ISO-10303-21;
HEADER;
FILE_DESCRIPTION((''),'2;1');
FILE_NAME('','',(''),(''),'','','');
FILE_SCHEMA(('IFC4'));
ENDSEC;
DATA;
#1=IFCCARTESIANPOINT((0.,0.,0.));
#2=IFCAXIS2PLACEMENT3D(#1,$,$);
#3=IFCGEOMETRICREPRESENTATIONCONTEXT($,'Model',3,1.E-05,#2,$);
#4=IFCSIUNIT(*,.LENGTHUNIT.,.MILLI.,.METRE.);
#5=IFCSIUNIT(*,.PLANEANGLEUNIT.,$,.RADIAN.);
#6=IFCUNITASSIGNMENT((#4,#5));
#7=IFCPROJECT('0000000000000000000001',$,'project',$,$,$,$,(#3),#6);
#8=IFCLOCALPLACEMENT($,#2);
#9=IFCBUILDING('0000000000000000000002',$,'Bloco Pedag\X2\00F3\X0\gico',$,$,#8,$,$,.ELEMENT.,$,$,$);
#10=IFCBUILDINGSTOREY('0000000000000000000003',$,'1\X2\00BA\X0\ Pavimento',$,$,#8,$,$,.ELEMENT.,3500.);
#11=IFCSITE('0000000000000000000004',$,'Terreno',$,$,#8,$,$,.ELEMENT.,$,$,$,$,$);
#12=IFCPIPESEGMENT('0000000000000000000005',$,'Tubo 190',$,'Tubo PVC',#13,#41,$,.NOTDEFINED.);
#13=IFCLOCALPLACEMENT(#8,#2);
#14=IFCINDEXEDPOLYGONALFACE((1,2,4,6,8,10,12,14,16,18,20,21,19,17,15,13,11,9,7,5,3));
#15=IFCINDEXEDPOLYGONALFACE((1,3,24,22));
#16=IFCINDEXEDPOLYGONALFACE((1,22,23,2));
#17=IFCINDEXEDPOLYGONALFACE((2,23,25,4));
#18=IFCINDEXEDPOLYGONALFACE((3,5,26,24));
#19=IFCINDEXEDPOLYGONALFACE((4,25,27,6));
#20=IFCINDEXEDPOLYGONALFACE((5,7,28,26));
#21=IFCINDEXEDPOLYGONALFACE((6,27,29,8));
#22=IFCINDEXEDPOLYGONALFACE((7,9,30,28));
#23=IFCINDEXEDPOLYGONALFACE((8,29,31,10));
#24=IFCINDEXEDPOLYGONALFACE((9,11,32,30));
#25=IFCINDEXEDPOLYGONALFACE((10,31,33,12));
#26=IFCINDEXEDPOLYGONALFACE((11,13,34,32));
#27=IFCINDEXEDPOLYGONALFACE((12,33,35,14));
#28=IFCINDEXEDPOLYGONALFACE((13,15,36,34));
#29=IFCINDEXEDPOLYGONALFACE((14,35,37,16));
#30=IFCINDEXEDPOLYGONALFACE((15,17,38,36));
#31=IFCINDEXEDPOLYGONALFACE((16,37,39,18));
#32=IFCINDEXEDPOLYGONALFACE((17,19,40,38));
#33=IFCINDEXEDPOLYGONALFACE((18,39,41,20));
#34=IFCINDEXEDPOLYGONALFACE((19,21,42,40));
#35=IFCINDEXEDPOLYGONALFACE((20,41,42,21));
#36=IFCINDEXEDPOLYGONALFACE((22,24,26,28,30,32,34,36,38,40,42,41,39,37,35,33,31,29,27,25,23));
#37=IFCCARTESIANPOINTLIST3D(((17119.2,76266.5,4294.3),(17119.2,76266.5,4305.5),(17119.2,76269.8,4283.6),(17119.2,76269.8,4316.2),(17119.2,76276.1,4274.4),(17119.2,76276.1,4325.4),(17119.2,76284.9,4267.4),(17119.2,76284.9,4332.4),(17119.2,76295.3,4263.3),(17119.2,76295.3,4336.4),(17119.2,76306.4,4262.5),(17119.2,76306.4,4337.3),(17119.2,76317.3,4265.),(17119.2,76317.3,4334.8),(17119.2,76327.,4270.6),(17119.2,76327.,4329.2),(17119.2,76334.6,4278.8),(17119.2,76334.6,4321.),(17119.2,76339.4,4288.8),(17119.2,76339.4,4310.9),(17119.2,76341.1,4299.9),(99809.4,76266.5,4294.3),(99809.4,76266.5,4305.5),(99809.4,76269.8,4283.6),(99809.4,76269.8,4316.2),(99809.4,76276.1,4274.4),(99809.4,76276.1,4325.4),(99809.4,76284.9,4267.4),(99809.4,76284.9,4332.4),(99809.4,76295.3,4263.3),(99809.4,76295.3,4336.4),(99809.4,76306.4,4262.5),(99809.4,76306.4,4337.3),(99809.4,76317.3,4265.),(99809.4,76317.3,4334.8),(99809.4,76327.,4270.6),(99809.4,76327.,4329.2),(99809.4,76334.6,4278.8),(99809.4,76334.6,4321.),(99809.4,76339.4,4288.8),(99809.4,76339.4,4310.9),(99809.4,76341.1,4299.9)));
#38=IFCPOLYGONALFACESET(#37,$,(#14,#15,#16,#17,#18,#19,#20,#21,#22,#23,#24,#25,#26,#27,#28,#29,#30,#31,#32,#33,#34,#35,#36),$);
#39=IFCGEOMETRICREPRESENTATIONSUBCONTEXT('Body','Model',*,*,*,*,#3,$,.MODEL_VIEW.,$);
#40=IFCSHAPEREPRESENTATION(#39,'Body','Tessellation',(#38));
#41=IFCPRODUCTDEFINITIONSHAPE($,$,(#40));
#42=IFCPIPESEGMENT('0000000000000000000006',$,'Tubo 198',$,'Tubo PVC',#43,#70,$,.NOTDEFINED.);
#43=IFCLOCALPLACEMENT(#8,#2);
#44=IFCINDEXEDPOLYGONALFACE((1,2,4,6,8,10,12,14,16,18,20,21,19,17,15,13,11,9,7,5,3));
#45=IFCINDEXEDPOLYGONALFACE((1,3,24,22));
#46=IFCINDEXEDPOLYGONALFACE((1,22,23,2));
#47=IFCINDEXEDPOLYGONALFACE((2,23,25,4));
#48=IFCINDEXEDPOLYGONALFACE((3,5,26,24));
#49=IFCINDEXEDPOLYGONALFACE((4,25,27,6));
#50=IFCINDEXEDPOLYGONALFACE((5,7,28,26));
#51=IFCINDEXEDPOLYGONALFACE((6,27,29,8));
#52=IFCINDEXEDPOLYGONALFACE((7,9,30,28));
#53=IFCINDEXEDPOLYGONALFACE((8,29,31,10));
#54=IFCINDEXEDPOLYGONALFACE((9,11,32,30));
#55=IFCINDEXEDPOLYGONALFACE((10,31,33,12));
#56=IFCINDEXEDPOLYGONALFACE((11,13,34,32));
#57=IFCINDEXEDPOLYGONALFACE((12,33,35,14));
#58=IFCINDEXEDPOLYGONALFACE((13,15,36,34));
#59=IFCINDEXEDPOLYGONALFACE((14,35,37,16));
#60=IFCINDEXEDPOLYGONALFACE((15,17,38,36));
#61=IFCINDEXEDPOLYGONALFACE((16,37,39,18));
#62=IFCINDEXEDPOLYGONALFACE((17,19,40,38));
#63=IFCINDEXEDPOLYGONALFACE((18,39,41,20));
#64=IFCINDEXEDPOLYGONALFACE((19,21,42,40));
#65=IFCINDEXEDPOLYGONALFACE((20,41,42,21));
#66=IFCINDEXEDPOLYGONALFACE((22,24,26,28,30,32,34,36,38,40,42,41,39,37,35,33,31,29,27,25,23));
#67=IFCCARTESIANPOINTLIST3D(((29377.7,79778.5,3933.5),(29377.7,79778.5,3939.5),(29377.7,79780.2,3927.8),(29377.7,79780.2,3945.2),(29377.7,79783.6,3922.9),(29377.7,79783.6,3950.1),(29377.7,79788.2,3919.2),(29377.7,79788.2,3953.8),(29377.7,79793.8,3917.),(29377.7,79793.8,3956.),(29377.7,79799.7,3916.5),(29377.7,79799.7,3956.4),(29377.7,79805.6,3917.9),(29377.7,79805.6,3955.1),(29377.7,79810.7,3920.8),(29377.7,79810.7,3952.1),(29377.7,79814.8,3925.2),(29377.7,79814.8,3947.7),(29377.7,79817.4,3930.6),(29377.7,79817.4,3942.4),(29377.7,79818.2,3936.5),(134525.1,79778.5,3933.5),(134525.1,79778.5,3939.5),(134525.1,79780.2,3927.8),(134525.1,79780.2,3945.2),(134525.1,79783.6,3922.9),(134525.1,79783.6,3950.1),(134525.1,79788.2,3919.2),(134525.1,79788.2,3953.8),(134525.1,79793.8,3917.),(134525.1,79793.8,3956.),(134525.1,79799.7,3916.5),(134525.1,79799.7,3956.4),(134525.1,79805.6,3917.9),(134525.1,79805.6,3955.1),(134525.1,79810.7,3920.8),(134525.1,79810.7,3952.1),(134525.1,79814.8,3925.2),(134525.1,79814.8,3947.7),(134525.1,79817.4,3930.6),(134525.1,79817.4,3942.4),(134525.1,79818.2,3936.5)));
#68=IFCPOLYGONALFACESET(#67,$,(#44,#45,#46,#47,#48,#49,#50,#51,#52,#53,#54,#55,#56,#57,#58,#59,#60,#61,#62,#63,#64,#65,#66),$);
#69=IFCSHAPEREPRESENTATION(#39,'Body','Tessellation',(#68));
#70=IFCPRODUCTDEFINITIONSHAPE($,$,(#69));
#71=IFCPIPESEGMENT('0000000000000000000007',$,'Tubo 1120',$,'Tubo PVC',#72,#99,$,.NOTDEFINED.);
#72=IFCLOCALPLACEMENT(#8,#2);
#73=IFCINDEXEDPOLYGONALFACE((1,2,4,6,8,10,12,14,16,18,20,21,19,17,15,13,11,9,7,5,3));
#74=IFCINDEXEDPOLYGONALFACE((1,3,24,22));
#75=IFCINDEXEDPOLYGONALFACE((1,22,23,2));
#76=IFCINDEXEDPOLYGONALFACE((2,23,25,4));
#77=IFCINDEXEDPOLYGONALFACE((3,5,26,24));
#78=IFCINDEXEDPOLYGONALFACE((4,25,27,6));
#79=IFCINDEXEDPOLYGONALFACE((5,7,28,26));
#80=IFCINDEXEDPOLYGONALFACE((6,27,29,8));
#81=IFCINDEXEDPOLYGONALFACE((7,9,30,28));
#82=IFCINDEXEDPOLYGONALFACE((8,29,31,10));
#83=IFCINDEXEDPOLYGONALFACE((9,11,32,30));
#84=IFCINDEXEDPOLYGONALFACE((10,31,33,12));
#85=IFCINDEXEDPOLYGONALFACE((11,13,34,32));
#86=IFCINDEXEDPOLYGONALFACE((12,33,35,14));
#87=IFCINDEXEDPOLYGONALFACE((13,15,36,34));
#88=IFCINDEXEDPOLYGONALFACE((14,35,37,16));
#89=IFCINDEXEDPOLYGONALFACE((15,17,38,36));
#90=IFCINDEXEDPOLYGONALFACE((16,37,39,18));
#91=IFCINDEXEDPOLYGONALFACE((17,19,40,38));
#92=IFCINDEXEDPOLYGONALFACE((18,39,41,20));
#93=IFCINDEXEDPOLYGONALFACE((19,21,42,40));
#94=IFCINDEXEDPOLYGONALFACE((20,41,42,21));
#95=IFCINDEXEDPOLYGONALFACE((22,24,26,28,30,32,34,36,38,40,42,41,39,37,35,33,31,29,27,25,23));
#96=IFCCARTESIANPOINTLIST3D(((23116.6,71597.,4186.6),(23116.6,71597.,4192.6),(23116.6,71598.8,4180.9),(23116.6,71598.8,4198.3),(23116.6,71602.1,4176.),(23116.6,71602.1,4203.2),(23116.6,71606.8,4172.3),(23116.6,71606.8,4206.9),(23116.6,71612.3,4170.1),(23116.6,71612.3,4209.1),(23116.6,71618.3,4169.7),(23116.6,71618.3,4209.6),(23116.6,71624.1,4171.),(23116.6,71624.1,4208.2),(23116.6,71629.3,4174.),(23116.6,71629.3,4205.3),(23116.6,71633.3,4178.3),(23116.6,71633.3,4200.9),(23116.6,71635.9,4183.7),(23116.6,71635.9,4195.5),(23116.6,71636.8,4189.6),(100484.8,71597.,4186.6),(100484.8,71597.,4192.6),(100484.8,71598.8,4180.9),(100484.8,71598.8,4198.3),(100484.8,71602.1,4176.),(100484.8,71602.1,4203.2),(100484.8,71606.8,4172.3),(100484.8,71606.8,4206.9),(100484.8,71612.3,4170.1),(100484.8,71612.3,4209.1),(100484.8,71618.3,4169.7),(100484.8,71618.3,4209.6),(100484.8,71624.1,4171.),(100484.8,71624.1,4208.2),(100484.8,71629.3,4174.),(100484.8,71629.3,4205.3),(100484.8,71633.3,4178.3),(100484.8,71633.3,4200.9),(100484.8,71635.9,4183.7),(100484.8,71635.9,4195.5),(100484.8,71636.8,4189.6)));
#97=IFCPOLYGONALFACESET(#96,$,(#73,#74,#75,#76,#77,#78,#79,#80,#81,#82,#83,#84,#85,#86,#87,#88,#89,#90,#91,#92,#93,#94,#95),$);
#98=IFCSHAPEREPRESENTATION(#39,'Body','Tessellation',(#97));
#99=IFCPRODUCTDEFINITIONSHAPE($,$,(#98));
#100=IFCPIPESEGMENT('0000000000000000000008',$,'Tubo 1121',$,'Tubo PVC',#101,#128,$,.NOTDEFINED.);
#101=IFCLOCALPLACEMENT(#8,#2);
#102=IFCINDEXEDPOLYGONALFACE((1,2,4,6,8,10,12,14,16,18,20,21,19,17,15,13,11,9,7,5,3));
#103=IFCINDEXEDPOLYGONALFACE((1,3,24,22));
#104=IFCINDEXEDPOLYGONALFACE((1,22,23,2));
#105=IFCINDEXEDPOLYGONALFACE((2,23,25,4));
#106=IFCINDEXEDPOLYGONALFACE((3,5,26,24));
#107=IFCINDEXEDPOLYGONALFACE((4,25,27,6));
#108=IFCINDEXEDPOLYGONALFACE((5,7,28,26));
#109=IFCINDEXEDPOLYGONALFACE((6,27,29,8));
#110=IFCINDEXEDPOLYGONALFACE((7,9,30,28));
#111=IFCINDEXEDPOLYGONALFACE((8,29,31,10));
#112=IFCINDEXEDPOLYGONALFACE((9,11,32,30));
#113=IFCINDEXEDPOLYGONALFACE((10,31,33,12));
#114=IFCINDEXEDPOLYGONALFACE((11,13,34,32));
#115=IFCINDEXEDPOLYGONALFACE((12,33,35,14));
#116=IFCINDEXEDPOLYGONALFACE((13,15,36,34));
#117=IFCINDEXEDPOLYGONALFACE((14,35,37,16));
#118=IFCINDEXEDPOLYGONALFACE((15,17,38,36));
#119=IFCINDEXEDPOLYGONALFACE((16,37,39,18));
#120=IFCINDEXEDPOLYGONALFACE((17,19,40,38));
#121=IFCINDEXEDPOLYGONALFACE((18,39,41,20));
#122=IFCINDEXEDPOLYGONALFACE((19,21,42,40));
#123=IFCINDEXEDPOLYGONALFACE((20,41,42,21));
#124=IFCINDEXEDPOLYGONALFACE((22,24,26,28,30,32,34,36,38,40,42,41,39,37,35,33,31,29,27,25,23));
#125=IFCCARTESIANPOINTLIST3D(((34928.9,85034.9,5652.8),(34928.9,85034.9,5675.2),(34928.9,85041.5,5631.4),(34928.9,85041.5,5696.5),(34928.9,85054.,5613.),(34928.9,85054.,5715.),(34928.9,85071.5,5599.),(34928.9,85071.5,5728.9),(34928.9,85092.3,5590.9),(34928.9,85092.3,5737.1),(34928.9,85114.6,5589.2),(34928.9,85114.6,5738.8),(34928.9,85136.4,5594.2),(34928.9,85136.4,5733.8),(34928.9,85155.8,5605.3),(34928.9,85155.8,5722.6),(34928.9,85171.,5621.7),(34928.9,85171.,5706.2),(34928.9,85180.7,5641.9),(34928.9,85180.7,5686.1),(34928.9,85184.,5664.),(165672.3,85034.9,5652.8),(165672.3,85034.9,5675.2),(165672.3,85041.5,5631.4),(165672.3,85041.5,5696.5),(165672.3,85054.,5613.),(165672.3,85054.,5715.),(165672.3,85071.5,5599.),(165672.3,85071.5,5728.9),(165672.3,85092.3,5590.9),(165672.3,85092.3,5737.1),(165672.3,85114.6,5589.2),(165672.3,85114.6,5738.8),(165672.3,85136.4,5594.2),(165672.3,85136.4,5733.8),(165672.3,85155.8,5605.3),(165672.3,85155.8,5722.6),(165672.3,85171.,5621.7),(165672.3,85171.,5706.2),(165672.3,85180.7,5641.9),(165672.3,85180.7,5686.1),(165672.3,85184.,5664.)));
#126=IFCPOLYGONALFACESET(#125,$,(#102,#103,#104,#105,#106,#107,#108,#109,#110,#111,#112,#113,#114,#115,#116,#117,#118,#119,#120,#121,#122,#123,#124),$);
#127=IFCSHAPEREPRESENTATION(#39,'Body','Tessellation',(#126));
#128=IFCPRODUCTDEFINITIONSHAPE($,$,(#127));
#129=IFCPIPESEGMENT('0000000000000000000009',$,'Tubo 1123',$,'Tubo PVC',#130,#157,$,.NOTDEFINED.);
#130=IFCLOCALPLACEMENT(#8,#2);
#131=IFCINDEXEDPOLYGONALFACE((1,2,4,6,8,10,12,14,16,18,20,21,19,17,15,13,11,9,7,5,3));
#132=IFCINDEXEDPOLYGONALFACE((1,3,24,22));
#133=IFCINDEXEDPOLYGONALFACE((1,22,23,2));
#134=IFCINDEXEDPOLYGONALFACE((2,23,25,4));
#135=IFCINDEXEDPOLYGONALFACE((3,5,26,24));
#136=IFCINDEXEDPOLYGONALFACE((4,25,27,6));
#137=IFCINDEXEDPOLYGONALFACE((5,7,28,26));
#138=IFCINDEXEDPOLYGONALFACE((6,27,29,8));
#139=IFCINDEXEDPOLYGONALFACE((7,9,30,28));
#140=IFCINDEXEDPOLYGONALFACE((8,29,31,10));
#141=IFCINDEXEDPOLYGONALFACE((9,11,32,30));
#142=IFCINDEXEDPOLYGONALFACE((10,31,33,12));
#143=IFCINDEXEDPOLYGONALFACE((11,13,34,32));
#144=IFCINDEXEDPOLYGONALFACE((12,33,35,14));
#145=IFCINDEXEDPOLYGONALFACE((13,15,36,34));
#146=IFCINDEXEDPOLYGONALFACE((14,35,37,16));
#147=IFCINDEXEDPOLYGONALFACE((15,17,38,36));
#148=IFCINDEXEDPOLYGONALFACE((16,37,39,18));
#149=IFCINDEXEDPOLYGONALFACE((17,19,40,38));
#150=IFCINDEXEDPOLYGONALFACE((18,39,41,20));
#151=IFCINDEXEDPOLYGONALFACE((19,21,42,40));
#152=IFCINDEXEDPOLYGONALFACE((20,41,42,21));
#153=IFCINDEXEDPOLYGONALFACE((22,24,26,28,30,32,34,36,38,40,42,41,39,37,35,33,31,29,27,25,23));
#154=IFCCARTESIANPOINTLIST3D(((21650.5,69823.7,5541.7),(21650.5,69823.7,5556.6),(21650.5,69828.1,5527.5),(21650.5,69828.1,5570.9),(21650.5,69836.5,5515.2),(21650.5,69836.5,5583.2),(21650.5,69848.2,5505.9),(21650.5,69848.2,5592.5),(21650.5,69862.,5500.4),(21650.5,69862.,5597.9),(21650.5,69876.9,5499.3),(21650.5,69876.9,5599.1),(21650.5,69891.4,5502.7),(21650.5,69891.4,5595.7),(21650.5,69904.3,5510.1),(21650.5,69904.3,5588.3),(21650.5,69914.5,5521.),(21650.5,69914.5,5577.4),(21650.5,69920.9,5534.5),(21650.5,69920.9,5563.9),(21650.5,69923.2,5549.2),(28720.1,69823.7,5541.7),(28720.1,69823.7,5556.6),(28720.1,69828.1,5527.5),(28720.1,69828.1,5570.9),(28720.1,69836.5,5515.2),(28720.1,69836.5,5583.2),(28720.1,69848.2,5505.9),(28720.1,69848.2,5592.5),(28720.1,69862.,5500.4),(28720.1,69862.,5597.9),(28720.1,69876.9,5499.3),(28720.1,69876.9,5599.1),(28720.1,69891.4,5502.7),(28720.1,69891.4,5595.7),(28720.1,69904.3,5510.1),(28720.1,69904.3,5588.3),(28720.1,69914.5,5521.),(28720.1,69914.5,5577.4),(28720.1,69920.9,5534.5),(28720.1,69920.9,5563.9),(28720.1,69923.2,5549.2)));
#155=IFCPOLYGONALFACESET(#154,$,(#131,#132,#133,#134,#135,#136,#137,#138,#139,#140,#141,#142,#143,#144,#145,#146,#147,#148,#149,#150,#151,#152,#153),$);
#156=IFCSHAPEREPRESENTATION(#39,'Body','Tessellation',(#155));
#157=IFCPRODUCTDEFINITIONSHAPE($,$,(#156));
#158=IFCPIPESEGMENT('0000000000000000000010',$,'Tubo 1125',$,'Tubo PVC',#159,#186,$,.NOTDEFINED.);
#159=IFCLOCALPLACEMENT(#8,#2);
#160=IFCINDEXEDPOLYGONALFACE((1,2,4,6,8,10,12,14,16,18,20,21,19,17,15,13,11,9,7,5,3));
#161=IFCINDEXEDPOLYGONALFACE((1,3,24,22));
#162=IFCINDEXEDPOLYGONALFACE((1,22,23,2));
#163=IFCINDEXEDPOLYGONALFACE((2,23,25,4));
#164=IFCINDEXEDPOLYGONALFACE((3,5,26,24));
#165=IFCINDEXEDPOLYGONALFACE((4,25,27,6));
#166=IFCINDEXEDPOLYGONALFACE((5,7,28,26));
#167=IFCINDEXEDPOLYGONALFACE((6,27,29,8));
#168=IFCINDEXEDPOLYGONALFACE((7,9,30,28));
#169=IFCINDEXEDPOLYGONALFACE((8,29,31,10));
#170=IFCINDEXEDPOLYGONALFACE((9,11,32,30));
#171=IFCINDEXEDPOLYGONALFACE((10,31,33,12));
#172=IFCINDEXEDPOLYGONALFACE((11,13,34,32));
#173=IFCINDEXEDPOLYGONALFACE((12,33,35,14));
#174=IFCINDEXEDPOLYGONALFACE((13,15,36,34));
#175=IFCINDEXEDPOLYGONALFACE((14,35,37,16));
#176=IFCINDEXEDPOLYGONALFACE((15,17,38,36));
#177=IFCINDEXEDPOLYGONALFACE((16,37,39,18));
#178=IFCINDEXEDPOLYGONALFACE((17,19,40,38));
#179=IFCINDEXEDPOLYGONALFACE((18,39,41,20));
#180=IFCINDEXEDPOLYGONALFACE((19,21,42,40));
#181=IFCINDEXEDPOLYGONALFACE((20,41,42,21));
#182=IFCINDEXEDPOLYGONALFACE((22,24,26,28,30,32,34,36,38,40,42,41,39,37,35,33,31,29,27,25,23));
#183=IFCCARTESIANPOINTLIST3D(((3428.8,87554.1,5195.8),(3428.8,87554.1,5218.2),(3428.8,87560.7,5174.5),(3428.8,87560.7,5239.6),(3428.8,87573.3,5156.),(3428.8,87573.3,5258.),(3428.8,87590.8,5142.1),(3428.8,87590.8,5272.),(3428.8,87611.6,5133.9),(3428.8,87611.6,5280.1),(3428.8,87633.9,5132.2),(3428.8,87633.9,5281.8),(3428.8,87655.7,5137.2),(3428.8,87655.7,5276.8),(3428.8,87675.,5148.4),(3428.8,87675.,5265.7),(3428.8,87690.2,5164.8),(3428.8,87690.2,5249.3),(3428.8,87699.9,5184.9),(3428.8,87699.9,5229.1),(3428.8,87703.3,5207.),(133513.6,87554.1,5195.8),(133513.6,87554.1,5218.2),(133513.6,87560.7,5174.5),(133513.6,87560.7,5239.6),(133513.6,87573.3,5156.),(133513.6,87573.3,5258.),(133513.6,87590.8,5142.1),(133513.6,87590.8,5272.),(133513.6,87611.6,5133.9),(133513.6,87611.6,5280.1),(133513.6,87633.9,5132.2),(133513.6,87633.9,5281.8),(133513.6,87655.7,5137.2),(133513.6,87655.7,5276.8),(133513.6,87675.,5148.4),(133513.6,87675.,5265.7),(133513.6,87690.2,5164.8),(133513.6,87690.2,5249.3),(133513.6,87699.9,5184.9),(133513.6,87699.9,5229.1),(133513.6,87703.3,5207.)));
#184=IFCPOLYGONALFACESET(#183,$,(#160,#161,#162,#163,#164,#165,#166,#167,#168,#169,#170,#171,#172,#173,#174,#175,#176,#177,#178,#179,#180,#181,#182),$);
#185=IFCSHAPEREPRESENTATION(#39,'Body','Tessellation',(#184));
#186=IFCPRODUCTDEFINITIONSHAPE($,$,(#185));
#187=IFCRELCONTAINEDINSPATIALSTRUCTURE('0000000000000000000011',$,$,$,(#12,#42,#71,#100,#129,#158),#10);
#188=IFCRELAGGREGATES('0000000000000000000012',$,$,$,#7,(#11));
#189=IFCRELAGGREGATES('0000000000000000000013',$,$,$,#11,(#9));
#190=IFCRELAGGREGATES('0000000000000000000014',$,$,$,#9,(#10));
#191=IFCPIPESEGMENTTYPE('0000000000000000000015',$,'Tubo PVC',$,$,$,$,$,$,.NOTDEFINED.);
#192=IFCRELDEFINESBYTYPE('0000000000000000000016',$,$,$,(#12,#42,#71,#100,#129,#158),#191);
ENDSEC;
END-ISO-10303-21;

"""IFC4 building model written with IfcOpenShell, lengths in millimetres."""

from ifc_helpers import new_model, si_unit, frame, origin, origin_2d, place, context, subcontext, project, spatial, circle, extrude, type_object, element, save


model = new_model("IFC4")

# Units and contexts
model_context = context("Model", 3, precision=1e-05, world=origin())
body_context = subcontext(model_context, "Body", "Model", "MODEL_VIEW")
ifc_project = project(units=[si_unit("LENGTHUNIT", "METRE", prefix="MILLI"), si_unit("PLANEANGLEUNIT", "RADIAN")], contexts=[model_context])

# Site, building, storey
placement = place(None, origin())
site = spatial("IfcSite", under=ifc_project, at=placement, Name="Terreno", CompositionType="ELEMENT")
building = spatial("IfcBuilding", under=site, at=placement, Name="Bloco Pedagógico", CompositionType="ELEMENT")
storey = spatial("IfcBuildingStorey", under=building, at=placement, Name="1º Pavimento", CompositionType="ELEMENT", Elevation=3500.0)

# Pipe segments
pipe_segment_type = type_object("IfcPipeSegmentType", Name="Tubo PVC", PredefinedType="NOTDEFINED")
pipe_segment_1_placement = place(None, frame((17119.2, 76303.6, 4299.9), z_axis=(1.0, 0.0, 0.0), x_axis=(0.0, 1.0, 0.0)))
element("IfcPipeSegment", 1, at=pipe_segment_1_placement, inside=storey, type_object=pipe_segment_type, Name="Tubo 190", ObjectType="Tubo PVC", PredefinedType="NOTDEFINED", context=body_context, shape_type="SweptSolid", body=[
    extrude(circle(Radius=37.5, at=origin_2d()), None, (0.0, 0.0, 1.0), 82690.2),
])
pipe_segment_2_placement = place(None, frame((29377.7, 79798.2, 3936.5), z_axis=(1.0, 0.0, 0.0), x_axis=(0.0, 1.0, 0.0)))
element("IfcPipeSegment", 2, at=pipe_segment_2_placement, inside=storey, type_object=pipe_segment_type, Name="Tubo 198", ObjectType="Tubo PVC", PredefinedType="NOTDEFINED", context=body_context, shape_type="SweptSolid", body=[
    extrude(circle(Radius=20.0, at=origin_2d()), None, (0.0, 0.0, 1.0), 105147.5),
])
pipe_segment_3_placement = place(None, frame((23116.6, 71616.8, 4189.6), z_axis=(1.0, 0.0, 0.0), x_axis=(0.0, 1.0, 0.0)))
element("IfcPipeSegment", 3, at=pipe_segment_3_placement, inside=storey, type_object=pipe_segment_type, Name="Tubo 1120", ObjectType="Tubo PVC", PredefinedType="NOTDEFINED", context=body_context, shape_type="SweptSolid", body=[
    extrude(circle(Radius=20.0, at=origin_2d()), None, (0.0, 0.0, 1.0), 77368.2),
])
pipe_segment_4_placement = place(None, frame((34928.9, 85109.0, 5664.0), z_axis=(1.0, 0.0, 0.0), x_axis=(0.0, 1.0, 0.0)))
element("IfcPipeSegment", 4, at=pipe_segment_4_placement, inside=storey, type_object=pipe_segment_type, Name="Tubo 1121", ObjectType="Tubo PVC", PredefinedType="NOTDEFINED", context=body_context, shape_type="SweptSolid", body=[
    extrude(circle(Radius=75.0, at=origin_2d()), None, (0.0, 0.0, 1.0), 130743.4),
])
pipe_segment_5_placement = place(None, frame((21650.5, 69873.2, 5549.2), z_axis=(1.0, 0.0, 0.0), x_axis=(0.0, 1.0, 0.0)))
element("IfcPipeSegment", 5, at=pipe_segment_5_placement, inside=storey, type_object=pipe_segment_type, Name="Tubo 1123", ObjectType="Tubo PVC", PredefinedType="NOTDEFINED", context=body_context, shape_type="SweptSolid", body=[
    extrude(circle(Radius=50.0, at=origin_2d()), None, (0.0, 0.0, 1.0), 7069.6),
])
pipe_segment_6_placement = place(None, frame((3428.8, 87628.3, 5207.0), z_axis=(1.0, 0.0, 0.0), x_axis=(0.0, 1.0, 0.0)))
element("IfcPipeSegment", 6, at=pipe_segment_6_placement, inside=storey, type_object=pipe_segment_type, Name="Tubo 1125", ObjectType="Tubo PVC", PredefinedType="NOTDEFINED", context=body_context, shape_type="SweptSolid", body=[
    extrude(circle(Radius=75.0, at=origin_2d()), None, (0.0, 0.0, 1.0), 130084.8),
])

save(model, "model.ifc")
